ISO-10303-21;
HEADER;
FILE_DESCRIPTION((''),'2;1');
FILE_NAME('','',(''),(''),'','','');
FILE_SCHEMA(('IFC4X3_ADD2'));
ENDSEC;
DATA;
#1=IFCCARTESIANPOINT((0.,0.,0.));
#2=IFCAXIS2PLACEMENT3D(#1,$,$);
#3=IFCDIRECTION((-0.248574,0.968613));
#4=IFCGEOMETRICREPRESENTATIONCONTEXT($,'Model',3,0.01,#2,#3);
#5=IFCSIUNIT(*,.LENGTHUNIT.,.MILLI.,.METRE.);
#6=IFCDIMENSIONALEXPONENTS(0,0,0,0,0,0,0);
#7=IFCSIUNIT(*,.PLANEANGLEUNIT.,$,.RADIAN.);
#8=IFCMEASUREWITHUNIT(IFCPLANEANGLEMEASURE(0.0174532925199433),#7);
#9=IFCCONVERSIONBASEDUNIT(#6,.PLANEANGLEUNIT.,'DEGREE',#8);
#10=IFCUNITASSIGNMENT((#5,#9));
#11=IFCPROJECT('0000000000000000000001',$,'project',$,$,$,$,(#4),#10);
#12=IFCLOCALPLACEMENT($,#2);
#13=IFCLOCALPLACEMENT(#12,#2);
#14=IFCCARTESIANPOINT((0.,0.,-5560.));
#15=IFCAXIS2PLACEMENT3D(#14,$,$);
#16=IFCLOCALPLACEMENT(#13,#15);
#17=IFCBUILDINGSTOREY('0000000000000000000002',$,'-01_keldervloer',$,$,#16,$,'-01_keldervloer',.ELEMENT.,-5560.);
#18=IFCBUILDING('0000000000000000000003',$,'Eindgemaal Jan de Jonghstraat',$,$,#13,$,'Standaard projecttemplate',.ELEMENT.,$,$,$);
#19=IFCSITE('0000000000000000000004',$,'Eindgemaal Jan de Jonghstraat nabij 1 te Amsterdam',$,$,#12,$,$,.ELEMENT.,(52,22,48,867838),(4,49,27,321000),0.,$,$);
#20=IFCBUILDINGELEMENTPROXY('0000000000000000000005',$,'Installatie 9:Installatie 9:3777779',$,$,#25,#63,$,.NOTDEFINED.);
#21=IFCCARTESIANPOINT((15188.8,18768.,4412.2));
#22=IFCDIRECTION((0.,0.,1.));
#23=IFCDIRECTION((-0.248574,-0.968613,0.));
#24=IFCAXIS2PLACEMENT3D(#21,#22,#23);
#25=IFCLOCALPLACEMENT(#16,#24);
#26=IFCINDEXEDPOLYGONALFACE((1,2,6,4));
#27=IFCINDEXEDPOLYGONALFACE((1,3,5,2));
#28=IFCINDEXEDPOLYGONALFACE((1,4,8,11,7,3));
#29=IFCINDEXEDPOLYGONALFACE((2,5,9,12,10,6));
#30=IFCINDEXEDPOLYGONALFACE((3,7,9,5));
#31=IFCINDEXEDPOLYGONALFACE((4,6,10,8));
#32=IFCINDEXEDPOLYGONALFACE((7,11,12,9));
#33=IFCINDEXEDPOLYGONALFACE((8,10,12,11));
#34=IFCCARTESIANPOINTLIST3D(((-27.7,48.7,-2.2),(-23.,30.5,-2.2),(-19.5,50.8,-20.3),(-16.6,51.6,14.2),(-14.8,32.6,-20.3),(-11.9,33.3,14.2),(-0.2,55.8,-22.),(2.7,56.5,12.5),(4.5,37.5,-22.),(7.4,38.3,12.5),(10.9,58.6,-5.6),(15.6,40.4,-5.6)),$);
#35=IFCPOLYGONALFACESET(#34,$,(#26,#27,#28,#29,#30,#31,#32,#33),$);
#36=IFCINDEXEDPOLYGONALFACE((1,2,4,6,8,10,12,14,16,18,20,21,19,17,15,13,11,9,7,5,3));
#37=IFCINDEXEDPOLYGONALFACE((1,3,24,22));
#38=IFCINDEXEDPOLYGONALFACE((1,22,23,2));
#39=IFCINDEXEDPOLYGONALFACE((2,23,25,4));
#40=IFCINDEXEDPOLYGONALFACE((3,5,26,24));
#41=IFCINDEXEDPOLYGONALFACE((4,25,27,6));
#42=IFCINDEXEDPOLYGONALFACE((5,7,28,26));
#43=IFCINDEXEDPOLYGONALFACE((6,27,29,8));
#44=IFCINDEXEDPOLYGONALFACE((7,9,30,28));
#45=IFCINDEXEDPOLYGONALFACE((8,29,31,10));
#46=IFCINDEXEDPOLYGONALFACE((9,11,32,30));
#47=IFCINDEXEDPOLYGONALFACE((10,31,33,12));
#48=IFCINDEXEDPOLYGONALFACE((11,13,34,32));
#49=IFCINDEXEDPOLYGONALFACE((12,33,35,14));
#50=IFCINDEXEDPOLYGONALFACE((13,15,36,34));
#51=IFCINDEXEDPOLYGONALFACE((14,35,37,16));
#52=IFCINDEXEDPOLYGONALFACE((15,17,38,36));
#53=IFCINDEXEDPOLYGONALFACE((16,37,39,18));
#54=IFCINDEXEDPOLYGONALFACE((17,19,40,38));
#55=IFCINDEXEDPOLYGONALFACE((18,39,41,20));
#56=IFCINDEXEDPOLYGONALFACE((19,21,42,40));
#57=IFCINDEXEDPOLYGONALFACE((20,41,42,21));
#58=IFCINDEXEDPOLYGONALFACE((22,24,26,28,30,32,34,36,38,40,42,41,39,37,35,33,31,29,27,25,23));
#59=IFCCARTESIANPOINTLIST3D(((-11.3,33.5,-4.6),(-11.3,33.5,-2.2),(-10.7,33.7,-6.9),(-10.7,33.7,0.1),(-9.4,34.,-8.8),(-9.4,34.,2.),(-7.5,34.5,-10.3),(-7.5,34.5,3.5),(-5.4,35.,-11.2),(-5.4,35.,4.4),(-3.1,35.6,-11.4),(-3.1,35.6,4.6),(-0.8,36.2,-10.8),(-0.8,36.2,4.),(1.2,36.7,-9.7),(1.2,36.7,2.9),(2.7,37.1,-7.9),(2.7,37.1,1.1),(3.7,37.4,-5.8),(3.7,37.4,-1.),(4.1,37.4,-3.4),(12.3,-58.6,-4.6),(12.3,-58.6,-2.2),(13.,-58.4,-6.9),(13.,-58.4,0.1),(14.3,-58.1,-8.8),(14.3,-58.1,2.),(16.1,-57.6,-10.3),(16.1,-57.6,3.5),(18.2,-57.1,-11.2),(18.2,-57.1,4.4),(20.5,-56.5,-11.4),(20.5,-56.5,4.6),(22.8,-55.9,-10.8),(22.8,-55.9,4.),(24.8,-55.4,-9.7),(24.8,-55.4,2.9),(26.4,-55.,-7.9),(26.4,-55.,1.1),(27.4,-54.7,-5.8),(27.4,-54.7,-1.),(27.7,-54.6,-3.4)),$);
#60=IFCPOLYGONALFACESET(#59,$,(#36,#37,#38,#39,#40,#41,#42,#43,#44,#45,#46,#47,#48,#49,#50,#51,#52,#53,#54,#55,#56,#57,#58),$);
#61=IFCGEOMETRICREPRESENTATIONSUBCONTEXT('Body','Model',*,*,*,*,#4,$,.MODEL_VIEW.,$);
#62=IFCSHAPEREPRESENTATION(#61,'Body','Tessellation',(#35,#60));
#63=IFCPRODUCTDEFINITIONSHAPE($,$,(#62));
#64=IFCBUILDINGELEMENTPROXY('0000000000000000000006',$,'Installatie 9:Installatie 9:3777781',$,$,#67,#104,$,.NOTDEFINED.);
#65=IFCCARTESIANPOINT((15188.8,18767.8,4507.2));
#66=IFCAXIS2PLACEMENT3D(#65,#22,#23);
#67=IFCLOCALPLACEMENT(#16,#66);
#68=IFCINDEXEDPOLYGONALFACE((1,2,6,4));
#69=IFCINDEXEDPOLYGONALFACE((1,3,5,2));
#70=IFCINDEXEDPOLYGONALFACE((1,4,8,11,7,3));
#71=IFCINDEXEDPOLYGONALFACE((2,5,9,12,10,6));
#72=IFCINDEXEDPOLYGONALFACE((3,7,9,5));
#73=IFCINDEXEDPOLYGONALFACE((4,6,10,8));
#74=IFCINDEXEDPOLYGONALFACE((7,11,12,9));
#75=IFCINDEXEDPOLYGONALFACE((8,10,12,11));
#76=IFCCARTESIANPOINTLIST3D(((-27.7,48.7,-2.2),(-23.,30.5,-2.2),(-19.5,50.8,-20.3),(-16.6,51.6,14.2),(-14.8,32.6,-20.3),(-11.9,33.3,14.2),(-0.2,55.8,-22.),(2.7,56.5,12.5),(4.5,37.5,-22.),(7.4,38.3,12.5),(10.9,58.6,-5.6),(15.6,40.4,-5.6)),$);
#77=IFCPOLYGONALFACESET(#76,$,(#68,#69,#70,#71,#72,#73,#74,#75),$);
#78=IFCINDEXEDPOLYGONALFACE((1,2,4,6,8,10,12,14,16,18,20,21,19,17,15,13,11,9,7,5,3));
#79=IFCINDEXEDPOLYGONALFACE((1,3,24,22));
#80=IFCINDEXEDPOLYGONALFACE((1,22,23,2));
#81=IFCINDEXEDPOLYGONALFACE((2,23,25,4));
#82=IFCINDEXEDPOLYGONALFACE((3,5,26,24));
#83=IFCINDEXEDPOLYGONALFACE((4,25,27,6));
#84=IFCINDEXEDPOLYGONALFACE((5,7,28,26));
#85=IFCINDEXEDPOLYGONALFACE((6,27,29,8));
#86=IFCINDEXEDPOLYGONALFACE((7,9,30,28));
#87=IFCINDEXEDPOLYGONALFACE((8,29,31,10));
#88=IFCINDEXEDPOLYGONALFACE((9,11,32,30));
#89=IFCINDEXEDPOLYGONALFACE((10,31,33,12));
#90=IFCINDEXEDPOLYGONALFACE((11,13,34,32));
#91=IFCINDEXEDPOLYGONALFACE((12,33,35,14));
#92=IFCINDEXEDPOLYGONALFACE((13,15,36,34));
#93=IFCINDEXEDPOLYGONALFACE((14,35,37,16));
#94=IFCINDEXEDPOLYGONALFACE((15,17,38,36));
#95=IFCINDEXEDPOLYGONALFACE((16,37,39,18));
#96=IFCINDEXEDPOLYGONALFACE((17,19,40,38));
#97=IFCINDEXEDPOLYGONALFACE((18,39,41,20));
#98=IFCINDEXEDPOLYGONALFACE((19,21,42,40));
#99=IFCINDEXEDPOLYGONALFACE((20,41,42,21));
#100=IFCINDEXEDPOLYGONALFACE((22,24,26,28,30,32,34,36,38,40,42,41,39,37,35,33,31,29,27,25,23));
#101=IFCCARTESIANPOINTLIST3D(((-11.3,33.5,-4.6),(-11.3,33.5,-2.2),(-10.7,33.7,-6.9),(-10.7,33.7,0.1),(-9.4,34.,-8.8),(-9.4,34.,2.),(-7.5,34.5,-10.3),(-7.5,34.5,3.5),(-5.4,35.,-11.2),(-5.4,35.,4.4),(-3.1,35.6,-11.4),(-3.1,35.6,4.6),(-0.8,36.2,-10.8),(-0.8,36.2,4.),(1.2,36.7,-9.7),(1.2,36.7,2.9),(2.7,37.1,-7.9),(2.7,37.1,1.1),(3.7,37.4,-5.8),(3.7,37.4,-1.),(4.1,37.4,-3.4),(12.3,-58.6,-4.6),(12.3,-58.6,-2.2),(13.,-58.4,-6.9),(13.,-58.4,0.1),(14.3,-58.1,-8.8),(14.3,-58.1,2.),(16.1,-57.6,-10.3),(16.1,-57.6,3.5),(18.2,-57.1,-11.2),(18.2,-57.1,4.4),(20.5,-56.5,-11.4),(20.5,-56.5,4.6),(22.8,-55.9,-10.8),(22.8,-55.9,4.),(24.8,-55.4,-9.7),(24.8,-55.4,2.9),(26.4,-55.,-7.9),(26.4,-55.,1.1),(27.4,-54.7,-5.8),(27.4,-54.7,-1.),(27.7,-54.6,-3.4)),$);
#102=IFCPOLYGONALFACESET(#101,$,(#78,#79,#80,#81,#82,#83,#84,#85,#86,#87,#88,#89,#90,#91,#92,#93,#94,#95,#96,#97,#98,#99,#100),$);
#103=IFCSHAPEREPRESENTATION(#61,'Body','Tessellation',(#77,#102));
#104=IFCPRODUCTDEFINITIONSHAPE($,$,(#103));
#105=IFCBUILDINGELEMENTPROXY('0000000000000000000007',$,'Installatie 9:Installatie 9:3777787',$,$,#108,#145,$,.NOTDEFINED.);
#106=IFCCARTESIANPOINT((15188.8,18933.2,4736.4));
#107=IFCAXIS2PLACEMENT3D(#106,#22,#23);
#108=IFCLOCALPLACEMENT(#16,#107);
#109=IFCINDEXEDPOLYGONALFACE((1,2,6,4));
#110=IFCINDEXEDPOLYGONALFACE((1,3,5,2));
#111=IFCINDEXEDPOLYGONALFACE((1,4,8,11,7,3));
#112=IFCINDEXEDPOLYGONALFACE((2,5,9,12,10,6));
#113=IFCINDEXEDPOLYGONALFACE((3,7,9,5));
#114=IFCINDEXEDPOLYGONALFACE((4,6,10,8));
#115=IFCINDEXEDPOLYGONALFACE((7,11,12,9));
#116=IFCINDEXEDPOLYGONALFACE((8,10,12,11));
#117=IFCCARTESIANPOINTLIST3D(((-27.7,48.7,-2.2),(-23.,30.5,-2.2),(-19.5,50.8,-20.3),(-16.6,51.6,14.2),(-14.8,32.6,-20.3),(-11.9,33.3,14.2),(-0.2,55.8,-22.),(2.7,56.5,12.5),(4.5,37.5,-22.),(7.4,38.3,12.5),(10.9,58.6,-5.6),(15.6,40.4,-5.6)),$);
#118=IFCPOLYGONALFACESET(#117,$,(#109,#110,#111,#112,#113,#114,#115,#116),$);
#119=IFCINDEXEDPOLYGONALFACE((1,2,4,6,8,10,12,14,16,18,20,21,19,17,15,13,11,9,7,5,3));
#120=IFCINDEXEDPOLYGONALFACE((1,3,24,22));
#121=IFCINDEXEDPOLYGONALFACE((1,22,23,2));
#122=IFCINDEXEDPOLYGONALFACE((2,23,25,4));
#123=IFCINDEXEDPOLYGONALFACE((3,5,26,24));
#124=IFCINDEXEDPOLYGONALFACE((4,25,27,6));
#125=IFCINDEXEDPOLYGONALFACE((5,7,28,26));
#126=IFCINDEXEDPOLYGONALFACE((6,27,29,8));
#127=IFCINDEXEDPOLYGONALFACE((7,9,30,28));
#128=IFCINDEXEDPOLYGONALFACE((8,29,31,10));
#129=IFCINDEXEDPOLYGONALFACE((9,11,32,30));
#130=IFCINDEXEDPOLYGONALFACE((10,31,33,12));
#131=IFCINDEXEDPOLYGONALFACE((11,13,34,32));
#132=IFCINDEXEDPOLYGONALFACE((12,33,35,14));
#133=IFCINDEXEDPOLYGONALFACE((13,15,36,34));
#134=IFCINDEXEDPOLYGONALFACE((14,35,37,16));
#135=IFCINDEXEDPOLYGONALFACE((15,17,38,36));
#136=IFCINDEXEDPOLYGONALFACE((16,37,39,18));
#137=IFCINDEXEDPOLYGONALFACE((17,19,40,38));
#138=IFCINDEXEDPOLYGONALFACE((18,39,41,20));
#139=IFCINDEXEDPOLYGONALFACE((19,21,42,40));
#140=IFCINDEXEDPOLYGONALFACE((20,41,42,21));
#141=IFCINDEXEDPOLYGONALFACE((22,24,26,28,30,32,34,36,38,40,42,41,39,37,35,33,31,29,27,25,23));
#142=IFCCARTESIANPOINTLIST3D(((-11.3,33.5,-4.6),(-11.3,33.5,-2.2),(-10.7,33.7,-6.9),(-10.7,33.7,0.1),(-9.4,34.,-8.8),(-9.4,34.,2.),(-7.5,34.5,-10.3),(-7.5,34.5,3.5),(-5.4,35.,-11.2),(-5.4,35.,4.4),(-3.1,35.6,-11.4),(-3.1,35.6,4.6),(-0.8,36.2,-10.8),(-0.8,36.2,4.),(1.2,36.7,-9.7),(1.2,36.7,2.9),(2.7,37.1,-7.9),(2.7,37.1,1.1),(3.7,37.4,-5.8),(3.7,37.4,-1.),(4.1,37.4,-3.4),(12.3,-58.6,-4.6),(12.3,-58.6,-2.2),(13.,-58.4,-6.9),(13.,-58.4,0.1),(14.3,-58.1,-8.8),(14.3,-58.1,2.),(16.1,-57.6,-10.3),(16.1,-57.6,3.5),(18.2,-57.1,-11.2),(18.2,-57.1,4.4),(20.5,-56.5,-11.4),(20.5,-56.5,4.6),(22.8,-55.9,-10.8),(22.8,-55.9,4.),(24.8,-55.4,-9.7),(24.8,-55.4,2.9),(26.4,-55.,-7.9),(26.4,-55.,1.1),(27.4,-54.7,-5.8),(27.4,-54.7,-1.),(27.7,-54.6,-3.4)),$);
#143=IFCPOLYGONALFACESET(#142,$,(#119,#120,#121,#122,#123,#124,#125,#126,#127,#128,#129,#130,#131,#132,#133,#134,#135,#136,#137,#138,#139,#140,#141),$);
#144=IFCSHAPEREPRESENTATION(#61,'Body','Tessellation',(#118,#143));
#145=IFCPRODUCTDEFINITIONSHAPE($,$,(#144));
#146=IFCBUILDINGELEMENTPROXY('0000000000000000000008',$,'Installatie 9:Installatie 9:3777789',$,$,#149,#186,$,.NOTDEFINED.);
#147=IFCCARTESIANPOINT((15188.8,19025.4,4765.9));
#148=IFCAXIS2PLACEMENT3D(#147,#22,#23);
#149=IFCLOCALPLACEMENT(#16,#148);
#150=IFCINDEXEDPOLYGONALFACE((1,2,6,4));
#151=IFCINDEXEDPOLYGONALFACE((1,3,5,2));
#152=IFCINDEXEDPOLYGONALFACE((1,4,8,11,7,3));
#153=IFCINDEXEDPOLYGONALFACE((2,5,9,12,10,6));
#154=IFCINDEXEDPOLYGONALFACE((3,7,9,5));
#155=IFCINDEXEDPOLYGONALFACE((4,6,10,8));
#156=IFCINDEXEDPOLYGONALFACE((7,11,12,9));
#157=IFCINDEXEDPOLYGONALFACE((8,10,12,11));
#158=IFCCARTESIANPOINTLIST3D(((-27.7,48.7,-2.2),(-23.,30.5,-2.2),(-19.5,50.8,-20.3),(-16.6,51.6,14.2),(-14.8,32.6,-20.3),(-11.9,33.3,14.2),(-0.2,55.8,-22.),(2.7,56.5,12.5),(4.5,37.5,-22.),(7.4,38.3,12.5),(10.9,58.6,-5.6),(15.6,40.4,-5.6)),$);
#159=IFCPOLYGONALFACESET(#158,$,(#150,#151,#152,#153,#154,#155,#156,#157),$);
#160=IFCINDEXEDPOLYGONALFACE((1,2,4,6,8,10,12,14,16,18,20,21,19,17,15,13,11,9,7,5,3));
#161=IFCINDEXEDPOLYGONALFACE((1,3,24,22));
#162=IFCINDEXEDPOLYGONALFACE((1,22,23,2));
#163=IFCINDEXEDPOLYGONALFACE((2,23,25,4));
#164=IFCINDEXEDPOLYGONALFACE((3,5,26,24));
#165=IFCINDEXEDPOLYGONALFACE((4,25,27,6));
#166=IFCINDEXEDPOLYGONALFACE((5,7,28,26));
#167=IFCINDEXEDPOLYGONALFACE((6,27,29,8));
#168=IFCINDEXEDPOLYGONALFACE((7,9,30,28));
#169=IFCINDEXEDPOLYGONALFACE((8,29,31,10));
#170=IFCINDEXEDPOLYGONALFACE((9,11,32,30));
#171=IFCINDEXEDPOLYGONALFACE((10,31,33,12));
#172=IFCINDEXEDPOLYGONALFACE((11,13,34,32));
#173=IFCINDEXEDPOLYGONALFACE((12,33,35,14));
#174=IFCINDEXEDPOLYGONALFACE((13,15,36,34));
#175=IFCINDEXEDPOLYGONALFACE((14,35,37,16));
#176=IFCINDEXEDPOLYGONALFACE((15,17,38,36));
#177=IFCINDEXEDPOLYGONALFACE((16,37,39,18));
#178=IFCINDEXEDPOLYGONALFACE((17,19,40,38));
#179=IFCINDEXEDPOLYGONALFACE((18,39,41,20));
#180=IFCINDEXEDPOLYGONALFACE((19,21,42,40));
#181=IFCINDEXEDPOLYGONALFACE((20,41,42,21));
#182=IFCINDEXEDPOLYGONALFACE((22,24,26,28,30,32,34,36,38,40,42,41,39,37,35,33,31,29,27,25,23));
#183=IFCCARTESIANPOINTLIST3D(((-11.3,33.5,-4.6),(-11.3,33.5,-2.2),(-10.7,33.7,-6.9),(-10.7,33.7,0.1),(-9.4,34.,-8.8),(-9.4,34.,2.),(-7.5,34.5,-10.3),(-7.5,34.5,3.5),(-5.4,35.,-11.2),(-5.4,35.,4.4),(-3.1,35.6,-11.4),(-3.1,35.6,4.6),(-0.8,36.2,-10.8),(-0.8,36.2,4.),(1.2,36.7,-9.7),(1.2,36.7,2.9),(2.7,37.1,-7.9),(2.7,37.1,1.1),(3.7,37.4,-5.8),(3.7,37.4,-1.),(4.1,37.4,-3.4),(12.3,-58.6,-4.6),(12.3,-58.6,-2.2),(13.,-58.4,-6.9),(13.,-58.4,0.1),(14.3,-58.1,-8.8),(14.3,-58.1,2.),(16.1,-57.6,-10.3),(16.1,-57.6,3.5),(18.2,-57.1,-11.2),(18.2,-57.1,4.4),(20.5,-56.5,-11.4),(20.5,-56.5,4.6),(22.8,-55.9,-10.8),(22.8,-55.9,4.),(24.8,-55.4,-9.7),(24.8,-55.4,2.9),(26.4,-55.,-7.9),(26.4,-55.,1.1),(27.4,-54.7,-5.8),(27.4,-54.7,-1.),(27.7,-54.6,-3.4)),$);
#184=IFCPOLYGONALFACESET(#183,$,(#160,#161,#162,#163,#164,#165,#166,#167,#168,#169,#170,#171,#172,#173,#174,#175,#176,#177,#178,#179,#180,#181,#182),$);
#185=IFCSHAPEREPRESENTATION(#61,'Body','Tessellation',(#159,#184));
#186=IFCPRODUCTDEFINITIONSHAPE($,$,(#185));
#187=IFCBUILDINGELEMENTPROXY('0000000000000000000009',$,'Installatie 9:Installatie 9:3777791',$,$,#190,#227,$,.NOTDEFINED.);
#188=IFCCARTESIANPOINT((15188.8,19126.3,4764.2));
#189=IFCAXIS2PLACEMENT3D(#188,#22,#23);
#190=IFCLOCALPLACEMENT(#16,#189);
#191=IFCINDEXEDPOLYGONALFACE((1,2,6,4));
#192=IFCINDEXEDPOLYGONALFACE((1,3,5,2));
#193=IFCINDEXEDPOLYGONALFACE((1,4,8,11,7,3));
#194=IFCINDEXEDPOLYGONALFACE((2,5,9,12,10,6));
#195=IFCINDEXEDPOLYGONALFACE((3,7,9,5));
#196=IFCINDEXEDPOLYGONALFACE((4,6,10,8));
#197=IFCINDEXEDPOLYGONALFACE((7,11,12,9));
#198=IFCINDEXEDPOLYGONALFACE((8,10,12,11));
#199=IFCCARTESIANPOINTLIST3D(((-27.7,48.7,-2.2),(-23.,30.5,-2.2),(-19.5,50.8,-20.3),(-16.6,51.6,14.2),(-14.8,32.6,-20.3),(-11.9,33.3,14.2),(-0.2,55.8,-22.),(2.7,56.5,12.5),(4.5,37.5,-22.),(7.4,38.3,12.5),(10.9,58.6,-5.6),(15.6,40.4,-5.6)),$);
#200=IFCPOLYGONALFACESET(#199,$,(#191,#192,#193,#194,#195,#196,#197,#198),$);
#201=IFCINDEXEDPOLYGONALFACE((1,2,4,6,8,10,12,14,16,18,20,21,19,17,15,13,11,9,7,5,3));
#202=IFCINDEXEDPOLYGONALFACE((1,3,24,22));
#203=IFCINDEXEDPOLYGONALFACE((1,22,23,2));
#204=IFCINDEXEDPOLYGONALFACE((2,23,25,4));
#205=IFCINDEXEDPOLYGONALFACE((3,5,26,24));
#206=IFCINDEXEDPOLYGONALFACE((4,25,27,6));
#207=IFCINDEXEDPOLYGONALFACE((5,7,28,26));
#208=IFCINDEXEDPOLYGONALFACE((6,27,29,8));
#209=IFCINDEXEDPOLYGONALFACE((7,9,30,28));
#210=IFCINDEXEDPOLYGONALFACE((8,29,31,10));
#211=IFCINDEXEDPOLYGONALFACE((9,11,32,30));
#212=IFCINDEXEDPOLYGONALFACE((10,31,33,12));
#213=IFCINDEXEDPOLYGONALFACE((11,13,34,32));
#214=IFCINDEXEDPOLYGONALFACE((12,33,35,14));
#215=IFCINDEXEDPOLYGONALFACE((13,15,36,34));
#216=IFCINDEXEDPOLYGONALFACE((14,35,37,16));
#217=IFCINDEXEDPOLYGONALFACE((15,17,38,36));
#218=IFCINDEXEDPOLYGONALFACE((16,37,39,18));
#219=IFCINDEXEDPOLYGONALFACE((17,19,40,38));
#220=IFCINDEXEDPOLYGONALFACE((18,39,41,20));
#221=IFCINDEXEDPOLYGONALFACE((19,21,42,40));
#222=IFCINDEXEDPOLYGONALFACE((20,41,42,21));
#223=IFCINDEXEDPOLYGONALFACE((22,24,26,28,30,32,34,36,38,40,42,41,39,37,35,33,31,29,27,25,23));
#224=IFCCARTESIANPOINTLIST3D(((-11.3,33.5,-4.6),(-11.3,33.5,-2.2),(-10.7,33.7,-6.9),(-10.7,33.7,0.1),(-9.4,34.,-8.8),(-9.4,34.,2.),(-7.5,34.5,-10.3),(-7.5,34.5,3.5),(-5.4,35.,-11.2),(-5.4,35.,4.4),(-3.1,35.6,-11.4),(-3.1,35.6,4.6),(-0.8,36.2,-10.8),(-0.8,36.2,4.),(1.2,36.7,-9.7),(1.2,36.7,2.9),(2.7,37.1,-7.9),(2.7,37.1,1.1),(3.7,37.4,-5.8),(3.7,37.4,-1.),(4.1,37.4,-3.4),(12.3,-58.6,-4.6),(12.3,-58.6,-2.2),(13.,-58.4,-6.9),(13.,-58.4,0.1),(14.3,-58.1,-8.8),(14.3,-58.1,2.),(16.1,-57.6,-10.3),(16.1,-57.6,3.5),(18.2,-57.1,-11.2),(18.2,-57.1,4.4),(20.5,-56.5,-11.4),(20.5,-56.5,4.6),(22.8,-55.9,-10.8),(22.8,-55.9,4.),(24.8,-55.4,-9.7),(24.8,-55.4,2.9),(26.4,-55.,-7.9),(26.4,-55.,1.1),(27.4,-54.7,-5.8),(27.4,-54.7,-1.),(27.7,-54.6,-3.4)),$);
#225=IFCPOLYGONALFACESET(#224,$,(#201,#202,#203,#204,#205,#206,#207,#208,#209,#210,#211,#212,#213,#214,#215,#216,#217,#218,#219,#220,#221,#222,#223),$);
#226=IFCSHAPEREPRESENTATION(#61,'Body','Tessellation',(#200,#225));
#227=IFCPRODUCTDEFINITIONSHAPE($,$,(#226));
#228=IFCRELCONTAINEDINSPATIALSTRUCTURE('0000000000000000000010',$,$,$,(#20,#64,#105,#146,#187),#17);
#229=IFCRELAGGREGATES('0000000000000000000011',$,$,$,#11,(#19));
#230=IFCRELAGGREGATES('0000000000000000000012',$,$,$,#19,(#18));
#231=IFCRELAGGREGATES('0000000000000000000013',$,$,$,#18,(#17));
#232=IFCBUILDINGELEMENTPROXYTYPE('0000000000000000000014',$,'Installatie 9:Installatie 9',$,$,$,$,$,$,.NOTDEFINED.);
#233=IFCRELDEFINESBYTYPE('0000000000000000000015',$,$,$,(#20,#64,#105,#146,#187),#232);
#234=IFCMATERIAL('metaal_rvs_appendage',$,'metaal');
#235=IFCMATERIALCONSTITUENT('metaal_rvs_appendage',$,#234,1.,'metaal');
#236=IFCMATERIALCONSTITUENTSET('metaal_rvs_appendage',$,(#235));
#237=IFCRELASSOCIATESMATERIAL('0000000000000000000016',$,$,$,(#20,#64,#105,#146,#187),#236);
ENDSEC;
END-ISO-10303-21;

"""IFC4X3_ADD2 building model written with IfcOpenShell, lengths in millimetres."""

from ifc_helpers import new_model, entity, si_unit, converted_unit, direction, frame, frame_2d, origin, place, context, subcontext, project, spatial, polyline, circle, outline, extrude, source, transform, mapped, material, constituent, constituent_set, type_object, type_shapes, element, save


model = new_model("IFC4X3_ADD2")

# Units and contexts
model_context = context("Model", 3, precision=0.01, world=origin(), true_north=direction((-0.248574, 0.968613)))
body_context = subcontext(model_context, "Body", "Model", "MODEL_VIEW")
ifc_project = project(units=[si_unit("LENGTHUNIT", "METRE", prefix="MILLI"), converted_unit("PLANEANGLEUNIT", "DEGREE", entity("IfcPlaneAngleMeasure", 0.0174532925199433), si_unit("PLANEANGLEUNIT", "RADIAN"), dimensions=[0, 0, 0, 0, 0, 0, 0])], contexts=[model_context])

# Site, building, storey
site_placement = place(None, origin())
site = spatial("IfcSite", under=ifc_project, at=site_placement, Name="Eindgemaal Jan de Jonghstraat nabij 1 te Amsterdam", CompositionType="ELEMENT", RefLatitude=(52, 22, 48, 867838), RefLongitude=(4, 49, 27, 321000), RefElevation=0.0)
building_placement = place(site_placement, origin())
building = spatial("IfcBuilding", under=site, at=building_placement, Name="Eindgemaal Jan de Jonghstraat", LongName="Standaard projecttemplate", CompositionType="ELEMENT")
storey_placement = place(building_placement, frame((0.0, 0.0, -5560.0)))
storey = spatial("IfcBuildingStorey", under=building, at=storey_placement, Name="-01_keldervloer", LongName="-01_keldervloer", CompositionType="ELEMENT", Elevation=-5560.0)

# Building element proxies
ifc_material_1 = material(Name="metaal_rvs_appendage", Category="metaal")
ifc_constituent_1 = constituent(ifc_material_1, Name="metaal_rvs_appendage", Category="metaal", fraction=1.0)
ifc_constituent_set_1 = constituent_set(constituents=[ifc_constituent_1], Name="metaal_rvs_appendage")
building_element_proxy_type = type_object("IfcBuildingElementProxyType", Name="Installatie 9:Installatie 9", PredefinedType="NOTDEFINED")
shared_shape_1 = source(origin(), body_context, "Body", "SweptSolid", [
    extrude(outline(polyline([(-10.0, -17.3), (10.0, -17.3), (20.0, 0.0), (10.0, 17.3), (-10.0, 17.3), (-20.0, 0.0), (-10.0, -17.3)])), frame((-3.7, 35.4, -3.9), z_axis=(-0.248574, 0.968613, 0.0), x_axis=(-0.555573, -0.142576, -0.819152)), (0.0, 0.0, 1.0), 18.8),
    extrude(circle(Radius=8.0, at=frame_2d((0.0, 0.0), x_axis=(1.0, 0.0))), frame((20.0, -56.6, -3.4), z_axis=(-0.248574, 0.968613, 0.0), x_axis=(0.968613, 0.248574, 0.0)), (0.0, 0.0, 1.0), 95.1),
])
type_shapes(building_element_proxy_type, [shared_shape_1])
for number, where, z_axis, x_axis, name in (
    (1, (15188.8, 18768.0, 4412.2), (0.0, 0.0, 1.0), (-0.248574, -0.968613, 0.0), "Installatie 9:Installatie 9:3777779"),
    (2, (15188.8, 18767.8, 4507.2), (0.0, 0.0, 1.0), (-0.248574, -0.968613, 0.0), "Installatie 9:Installatie 9:3777781"),
    (3, (15188.8, 18933.2, 4736.4), (0.0, 0.0, 1.0), (-0.248574, -0.968613, 0.0), "Installatie 9:Installatie 9:3777787"),
    (4, (15188.8, 19025.4, 4765.9), (0.0, 0.0, 1.0), (-0.248574, -0.968613, 0.0), "Installatie 9:Installatie 9:3777789"),
    (5, (15188.8, 19126.3, 4764.2), (0.0, 0.0, 1.0), (-0.248574, -0.968613, 0.0), "Installatie 9:Installatie 9:3777791"),
):
    element("IfcBuildingElementProxy", number, at=place(storey_placement, frame(where, z_axis=z_axis, x_axis=x_axis)), inside=storey, type_object=building_element_proxy_type, material=ifc_constituent_set_1, Name=name, PredefinedType="NOTDEFINED", context=body_context, shape_type="MappedRepresentation", body=[
        mapped(shared_shape_1, transform((0.0, 0.0, 0.0), scale=1.0)),
    ])

save(model, "model.ifc")
